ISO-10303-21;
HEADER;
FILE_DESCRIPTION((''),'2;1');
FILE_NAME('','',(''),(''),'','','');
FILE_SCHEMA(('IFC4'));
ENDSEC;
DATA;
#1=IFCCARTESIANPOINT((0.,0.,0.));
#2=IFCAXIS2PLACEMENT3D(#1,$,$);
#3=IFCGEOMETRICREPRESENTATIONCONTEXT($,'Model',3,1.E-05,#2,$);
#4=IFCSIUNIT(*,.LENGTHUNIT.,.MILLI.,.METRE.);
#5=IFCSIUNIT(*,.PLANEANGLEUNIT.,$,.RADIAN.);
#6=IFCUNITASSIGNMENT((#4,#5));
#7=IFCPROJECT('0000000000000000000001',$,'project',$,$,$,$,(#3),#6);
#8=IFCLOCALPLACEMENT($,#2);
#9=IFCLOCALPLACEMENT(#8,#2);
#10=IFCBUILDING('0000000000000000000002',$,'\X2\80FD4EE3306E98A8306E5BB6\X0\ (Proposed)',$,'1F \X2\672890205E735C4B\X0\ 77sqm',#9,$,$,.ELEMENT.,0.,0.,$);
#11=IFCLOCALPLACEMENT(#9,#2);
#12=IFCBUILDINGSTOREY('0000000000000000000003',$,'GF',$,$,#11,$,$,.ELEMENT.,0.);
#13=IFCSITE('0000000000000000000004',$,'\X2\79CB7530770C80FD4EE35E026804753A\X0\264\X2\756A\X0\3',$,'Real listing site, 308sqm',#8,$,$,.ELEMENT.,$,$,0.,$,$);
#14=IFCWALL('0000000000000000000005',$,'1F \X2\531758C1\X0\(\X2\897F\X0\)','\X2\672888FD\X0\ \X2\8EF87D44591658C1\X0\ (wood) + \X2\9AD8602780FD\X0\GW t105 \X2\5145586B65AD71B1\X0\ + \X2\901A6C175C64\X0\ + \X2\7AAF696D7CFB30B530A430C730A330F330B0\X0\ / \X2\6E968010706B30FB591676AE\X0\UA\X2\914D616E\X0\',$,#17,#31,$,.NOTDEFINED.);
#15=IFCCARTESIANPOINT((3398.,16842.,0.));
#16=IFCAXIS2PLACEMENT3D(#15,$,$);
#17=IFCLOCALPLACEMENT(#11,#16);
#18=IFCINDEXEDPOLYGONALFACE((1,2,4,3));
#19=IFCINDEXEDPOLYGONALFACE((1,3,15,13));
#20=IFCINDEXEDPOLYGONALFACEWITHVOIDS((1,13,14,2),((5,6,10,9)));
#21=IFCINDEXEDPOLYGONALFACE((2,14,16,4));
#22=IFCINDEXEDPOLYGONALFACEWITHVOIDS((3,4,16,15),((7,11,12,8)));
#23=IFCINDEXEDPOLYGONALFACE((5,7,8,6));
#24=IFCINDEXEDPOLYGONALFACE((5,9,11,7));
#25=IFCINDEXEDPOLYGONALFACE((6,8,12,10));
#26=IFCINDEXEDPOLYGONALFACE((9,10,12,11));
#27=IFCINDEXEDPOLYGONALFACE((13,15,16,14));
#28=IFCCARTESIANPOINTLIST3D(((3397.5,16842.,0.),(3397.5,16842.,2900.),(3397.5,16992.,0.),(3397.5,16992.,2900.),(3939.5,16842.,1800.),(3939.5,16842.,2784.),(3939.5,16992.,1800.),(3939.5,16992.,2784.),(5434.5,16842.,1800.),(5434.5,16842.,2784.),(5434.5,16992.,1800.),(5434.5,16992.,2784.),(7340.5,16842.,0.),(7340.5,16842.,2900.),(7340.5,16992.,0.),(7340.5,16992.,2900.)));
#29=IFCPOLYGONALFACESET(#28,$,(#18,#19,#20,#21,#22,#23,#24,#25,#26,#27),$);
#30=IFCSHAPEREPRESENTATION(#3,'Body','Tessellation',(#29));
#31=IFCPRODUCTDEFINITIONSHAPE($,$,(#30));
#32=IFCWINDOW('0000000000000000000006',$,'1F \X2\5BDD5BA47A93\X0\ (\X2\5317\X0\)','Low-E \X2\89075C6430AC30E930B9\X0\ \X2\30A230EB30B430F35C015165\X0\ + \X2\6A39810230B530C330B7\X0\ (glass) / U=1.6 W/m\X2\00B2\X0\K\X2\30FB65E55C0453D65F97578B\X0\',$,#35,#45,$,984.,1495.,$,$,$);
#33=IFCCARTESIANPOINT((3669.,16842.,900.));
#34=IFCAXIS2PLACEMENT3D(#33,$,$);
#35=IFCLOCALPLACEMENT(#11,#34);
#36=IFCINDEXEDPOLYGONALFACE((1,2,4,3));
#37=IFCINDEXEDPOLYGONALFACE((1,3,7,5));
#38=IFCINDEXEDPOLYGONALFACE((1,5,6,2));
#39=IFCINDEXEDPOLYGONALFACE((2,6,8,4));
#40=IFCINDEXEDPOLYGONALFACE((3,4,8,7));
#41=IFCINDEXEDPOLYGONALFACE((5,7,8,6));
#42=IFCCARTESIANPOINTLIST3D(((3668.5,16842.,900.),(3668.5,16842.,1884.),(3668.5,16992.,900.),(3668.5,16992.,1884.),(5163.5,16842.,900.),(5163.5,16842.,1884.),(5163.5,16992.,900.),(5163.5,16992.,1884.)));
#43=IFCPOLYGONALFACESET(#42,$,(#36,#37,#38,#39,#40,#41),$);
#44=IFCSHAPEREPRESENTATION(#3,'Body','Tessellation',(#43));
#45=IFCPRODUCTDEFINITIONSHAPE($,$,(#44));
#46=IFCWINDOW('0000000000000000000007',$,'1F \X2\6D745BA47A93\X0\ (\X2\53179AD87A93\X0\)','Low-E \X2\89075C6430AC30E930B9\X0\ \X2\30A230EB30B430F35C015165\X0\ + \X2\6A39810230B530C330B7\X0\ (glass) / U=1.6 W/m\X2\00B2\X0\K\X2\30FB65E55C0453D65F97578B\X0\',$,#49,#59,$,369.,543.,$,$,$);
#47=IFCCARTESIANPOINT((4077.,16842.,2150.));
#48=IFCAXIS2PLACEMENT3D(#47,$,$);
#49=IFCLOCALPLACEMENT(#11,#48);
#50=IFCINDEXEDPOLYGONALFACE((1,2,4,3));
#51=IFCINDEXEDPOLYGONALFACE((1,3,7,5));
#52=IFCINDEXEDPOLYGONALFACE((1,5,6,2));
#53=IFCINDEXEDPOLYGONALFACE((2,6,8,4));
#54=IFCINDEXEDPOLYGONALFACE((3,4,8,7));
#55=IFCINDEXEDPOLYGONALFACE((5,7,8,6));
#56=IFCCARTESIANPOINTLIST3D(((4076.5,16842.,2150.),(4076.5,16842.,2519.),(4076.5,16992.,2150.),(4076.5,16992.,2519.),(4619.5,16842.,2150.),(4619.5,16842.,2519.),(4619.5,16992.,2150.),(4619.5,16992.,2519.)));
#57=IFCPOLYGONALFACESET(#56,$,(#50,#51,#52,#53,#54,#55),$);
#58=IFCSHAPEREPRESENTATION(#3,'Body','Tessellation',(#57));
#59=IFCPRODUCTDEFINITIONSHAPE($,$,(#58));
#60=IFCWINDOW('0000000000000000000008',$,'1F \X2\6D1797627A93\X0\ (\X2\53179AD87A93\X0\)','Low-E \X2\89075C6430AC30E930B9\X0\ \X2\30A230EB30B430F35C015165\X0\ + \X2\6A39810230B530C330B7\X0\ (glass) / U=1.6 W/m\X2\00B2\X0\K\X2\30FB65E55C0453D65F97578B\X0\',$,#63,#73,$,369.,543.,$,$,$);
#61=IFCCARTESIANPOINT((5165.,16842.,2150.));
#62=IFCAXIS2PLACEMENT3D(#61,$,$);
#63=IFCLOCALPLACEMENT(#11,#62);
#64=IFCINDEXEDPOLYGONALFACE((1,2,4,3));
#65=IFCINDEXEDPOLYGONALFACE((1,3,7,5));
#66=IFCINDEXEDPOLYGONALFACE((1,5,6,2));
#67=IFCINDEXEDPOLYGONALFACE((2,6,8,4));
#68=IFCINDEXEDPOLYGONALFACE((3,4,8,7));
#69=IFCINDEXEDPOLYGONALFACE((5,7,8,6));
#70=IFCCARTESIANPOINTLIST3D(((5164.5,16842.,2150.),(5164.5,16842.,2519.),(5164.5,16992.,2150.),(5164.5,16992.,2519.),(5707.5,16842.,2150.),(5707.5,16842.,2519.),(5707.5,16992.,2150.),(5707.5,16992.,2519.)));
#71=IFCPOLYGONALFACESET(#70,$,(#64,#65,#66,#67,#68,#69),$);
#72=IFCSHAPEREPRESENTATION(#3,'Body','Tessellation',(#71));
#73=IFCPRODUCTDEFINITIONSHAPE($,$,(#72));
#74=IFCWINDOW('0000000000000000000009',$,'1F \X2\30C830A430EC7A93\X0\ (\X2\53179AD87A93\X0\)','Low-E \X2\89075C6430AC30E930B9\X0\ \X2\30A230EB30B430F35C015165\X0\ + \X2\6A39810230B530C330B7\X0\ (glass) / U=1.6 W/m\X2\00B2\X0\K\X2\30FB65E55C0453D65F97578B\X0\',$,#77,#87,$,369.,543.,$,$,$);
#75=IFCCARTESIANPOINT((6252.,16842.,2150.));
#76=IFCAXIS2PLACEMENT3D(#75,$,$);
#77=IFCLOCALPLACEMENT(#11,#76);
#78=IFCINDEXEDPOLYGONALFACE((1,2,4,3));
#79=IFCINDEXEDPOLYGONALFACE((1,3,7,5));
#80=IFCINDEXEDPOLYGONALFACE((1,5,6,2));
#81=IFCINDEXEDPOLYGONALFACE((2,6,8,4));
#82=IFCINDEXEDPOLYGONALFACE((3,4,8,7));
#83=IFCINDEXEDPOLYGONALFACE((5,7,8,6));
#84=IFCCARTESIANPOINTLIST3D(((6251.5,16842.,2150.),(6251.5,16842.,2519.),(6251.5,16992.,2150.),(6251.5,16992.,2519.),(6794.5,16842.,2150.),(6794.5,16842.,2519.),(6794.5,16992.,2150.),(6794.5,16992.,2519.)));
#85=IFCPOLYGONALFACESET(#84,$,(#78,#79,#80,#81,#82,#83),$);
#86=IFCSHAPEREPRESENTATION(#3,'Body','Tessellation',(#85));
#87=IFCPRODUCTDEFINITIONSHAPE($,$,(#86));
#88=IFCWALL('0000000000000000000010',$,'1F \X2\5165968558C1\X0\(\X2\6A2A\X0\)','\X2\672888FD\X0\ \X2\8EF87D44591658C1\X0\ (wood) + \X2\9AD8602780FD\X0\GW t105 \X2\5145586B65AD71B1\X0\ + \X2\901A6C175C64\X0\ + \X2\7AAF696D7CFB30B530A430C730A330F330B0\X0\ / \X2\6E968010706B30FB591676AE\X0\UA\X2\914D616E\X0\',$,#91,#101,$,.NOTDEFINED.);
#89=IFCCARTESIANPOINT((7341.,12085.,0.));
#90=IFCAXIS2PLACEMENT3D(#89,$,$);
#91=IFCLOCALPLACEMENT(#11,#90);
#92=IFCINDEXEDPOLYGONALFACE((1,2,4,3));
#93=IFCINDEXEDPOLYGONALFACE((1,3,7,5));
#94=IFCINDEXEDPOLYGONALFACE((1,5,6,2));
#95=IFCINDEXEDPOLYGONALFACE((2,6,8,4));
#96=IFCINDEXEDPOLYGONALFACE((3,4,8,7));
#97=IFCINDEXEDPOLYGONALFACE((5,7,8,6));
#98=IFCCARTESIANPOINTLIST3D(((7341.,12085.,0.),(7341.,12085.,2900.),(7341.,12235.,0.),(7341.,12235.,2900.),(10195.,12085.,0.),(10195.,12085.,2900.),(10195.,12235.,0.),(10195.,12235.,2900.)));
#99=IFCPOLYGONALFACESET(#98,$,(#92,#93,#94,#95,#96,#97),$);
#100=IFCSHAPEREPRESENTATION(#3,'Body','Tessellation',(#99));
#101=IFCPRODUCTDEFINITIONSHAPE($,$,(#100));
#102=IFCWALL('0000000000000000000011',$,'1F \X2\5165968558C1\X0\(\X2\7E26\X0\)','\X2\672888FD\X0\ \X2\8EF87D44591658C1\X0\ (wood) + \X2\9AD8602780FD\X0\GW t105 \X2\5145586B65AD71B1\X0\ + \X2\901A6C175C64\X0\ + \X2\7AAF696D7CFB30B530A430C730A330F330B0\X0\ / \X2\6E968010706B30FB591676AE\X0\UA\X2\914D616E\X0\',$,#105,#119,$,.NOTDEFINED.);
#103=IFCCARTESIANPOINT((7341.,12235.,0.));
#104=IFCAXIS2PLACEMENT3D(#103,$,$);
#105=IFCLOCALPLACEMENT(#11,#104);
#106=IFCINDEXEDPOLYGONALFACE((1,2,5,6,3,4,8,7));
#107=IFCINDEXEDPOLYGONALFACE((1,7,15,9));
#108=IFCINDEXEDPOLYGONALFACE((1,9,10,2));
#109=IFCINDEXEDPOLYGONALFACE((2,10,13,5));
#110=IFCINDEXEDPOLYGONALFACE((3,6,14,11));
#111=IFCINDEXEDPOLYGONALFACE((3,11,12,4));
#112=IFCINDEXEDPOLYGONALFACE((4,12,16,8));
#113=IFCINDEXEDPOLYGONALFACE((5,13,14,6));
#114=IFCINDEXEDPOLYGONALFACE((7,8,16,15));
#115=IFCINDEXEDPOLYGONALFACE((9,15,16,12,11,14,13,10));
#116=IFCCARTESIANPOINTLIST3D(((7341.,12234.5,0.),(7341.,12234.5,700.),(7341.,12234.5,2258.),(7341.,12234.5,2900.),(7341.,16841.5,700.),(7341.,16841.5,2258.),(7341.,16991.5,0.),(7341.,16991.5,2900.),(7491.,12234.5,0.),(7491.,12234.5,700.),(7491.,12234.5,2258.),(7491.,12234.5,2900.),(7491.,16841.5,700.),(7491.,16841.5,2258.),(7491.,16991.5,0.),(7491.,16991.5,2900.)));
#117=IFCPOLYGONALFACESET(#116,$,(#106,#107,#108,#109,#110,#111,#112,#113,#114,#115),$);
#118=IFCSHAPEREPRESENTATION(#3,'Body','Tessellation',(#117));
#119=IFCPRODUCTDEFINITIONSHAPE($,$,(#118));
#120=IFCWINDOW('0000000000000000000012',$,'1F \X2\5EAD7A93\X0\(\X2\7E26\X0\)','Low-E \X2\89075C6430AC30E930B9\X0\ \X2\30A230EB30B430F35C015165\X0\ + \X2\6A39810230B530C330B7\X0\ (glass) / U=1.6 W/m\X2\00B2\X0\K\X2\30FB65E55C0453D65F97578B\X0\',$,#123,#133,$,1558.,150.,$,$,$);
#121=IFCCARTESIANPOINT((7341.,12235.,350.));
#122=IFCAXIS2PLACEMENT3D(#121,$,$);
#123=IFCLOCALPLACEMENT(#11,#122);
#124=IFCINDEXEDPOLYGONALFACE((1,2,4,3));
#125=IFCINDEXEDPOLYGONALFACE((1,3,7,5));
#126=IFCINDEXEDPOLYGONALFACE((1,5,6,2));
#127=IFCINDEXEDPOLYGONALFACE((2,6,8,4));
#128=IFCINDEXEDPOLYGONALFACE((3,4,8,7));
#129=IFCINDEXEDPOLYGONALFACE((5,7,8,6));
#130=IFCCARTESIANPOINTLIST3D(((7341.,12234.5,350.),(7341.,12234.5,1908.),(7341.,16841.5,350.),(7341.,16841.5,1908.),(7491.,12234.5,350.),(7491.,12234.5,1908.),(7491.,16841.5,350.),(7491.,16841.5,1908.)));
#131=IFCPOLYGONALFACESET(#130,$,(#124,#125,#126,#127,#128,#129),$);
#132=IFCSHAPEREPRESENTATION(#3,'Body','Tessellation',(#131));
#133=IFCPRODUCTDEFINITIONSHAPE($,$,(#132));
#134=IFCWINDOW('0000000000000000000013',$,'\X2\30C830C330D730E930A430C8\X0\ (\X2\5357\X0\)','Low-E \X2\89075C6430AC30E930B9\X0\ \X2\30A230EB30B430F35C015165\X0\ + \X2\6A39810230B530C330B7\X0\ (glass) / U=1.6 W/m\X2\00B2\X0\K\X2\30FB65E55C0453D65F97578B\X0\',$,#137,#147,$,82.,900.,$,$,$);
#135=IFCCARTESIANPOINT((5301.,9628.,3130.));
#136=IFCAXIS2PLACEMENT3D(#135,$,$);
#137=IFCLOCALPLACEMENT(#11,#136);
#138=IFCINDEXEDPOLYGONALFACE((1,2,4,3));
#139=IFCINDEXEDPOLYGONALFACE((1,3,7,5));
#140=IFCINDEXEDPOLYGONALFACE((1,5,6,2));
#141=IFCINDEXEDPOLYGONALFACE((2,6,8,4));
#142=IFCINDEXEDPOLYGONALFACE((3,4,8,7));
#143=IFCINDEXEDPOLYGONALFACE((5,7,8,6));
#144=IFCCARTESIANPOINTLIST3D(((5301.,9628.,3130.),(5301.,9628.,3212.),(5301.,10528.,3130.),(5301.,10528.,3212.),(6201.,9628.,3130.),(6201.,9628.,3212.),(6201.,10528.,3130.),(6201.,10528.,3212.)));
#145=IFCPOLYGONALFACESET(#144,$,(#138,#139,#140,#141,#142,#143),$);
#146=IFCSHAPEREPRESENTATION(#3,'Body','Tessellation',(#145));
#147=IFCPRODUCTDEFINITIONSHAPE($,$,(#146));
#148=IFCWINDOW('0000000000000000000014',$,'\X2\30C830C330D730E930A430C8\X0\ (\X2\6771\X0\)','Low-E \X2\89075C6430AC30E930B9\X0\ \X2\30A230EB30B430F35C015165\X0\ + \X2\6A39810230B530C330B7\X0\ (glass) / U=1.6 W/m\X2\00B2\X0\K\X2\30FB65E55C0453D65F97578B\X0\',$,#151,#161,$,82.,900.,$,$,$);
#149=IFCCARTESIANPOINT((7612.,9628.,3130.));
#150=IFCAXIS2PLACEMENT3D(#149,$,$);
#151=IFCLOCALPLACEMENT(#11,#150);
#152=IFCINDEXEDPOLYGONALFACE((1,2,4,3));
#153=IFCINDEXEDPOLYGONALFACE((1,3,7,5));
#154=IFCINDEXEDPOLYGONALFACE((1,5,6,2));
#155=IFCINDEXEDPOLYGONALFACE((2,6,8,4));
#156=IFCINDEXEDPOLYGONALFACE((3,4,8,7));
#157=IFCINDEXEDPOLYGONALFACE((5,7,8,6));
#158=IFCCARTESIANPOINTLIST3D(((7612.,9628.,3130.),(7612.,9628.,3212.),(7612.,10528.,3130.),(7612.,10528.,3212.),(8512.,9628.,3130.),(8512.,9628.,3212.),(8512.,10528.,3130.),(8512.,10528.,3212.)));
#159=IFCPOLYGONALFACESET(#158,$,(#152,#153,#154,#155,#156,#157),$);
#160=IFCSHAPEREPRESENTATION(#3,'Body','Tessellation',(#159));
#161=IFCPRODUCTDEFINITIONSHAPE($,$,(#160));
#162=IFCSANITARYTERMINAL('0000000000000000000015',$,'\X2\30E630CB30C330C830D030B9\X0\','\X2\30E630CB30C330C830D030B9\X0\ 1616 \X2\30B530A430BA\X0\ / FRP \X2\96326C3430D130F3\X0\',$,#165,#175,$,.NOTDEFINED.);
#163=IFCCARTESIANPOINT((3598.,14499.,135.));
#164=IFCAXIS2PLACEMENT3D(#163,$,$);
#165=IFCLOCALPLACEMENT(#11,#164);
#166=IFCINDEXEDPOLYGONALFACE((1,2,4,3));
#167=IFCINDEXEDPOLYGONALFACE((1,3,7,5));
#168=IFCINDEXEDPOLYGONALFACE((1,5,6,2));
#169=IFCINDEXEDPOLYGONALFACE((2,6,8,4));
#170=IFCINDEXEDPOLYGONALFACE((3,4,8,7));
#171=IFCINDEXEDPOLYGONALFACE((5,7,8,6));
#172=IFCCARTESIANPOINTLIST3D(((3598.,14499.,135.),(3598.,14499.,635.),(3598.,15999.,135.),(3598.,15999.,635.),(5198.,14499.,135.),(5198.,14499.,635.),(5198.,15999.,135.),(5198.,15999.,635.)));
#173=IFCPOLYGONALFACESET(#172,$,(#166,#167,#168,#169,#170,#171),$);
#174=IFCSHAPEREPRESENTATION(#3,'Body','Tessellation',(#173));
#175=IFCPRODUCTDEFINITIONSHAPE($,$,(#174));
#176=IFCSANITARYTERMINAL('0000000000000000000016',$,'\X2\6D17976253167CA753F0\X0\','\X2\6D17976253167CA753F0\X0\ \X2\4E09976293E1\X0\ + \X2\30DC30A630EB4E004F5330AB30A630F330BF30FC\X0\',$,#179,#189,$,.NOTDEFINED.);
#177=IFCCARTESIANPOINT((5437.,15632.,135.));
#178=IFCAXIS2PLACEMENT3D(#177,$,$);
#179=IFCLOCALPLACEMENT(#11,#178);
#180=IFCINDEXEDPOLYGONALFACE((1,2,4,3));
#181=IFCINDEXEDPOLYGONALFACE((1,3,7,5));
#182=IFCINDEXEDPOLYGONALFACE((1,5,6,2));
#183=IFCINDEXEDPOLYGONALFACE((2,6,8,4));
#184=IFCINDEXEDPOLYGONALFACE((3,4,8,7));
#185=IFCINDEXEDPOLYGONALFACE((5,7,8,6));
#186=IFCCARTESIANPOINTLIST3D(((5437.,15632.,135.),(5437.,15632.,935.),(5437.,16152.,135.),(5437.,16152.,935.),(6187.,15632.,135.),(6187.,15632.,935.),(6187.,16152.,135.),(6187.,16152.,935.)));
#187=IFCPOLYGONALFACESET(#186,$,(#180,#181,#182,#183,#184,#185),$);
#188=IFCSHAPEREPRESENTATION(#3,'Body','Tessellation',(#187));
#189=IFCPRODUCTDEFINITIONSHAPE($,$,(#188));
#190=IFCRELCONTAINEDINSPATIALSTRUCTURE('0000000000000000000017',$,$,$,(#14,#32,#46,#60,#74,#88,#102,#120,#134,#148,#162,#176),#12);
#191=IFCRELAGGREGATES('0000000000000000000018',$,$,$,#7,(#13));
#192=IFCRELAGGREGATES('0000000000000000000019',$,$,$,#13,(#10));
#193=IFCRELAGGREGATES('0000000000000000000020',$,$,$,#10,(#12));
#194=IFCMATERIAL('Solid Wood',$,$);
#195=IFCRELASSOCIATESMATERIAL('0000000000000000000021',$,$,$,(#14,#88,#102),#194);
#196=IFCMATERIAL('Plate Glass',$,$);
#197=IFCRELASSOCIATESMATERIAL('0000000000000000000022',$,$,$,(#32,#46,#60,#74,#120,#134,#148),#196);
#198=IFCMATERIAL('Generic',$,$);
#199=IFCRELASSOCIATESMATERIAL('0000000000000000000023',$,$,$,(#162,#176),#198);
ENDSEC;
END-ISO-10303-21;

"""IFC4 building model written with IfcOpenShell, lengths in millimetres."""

from ifc_helpers import new_model, si_unit, frame, frame_2d, origin, place, context, project, spatial, rectangle, extrude, material, element, fill, save


model = new_model("IFC4")

# Units and contexts
model_context = context("Model", 3, precision=1e-05, world=origin())
ifc_project = project(units=[si_unit("LENGTHUNIT", "METRE", prefix="MILLI"), si_unit("PLANEANGLEUNIT", "RADIAN")], contexts=[model_context])

# Site, building, storey
site_placement = place(None, origin())
site = spatial("IfcSite", under=ifc_project, at=site_placement, Name="秋田県能代市栄町264番3", ObjectType="Real listing site, 308sqm", CompositionType="ELEMENT", RefElevation=0.0)
building_placement = place(site_placement, origin())
building = spatial("IfcBuilding", under=site, at=building_placement, Name="能代の風の家 (Proposed)", ObjectType="1F 木造平屋 77sqm", CompositionType="ELEMENT", ElevationOfRefHeight=0.0, ElevationOfTerrain=0.0)
storey_placement = place(building_placement, origin())
storey = spatial("IfcBuildingStorey", under=building, at=storey_placement, Name="GF", CompositionType="ELEMENT", Elevation=0.0)

# Shared definitions
ifc_material_1 = material(Name="Solid Wood")

# Wall, openings, windows
wall_1_placement = place(storey_placement, frame((3398.0, 16842.0, 0.0)))
wall_1 = element("IfcWall", 1, at=wall_1_placement, inside=storey, material=ifc_material_1, Name="1F 北壁(西)", Description="木製 軸組外壁 (wood) + 高性能GW t105 充填断熱 + 通気層 + 窯業系サイディング / 準耐火・外皮UA配慮", PredefinedType="NOTDEFINED", context=model_context, shape_type="SweptSolid", body=[
    extrude(rectangle(XDim=3943.0, YDim=150.0, at=frame_2d((1971.0, 75.0))), frame((3398.0, 16842.0, 0.0)), (0.0, 0.0, 1.0), 2900.0),
])
opening_1_placement = place(storey_placement, frame((3669.0, 16842.0, 900.0)))
opening_1 = element("IfcOpeningElement", 2, at=opening_1_placement, cuts=wall_1, PredefinedType="NOTDEFINED", context=model_context, shape_type="SweptSolid", body=[
    extrude(rectangle(XDim=1495.0, YDim=150.0, at=frame_2d((747.0, 75.0))), frame((3669.0, 16842.0, 900.0)), (0.0, 0.0, 1.0), 984.0),
])
opening_2_placement = place(storey_placement, frame((4077.0, 16842.0, 2150.0)))
opening_2 = element("IfcOpeningElement", 3, at=opening_2_placement, cuts=wall_1, PredefinedType="NOTDEFINED", context=model_context, shape_type="SweptSolid", body=[
    extrude(rectangle(XDim=543.0, YDim=150.0, at=frame_2d((271.0, 75.0))), frame((4077.0, 16842.0, 2150.0)), (0.0, 0.0, 1.0), 369.0),
])
opening_3_placement = place(storey_placement, frame((5165.0, 16842.0, 2150.0)))
opening_3 = element("IfcOpeningElement", 4, at=opening_3_placement, cuts=wall_1, PredefinedType="NOTDEFINED", context=model_context, shape_type="SweptSolid", body=[
    extrude(rectangle(XDim=543.0, YDim=150.0, at=frame_2d((271.0, 75.0))), frame((5165.0, 16842.0, 2150.0)), (0.0, 0.0, 1.0), 369.0),
])
opening_4_placement = place(storey_placement, frame((6252.0, 16842.0, 2150.0)))
opening_4 = element("IfcOpeningElement", 5, at=opening_4_placement, cuts=wall_1, PredefinedType="NOTDEFINED", context=model_context, shape_type="SweptSolid", body=[
    extrude(rectangle(XDim=543.0, YDim=150.0, at=frame_2d((271.0, 75.0))), frame((6252.0, 16842.0, 2150.0)), (0.0, 0.0, 1.0), 369.0),
])
ifc_material_2 = material(Name="Plate Glass")
window_1_placement = place(storey_placement, frame((3669.0, 16842.0, 900.0)))
window_1 = element("IfcWindow", 6, at=window_1_placement, inside=storey, material=ifc_material_2, Name="1F 寝室窓 (北)", Description="Low-E 複層ガラス アルゴン封入 + 樹脂サッシ (glass) / U=1.6 W/m²K・日射取得型", OverallHeight=984.0, OverallWidth=1495.0, context=model_context, shape_type="SweptSolid", body=[
    extrude(rectangle(XDim=1495.0, YDim=150.0, at=frame_2d((747.0, 75.0))), frame((3669.0, 16842.0, 900.0)), (0.0, 0.0, 1.0), 984.0),
])
fill(opening_1, window_1)
window_2_placement = place(storey_placement, frame((4077.0, 16842.0, 2150.0)))
window_2 = element("IfcWindow", 7, at=window_2_placement, inside=storey, material=ifc_material_2, Name="1F 浴室窓 (北高窓)", Description="Low-E 複層ガラス アルゴン封入 + 樹脂サッシ (glass) / U=1.6 W/m²K・日射取得型", OverallHeight=369.0, OverallWidth=543.0, context=model_context, shape_type="SweptSolid", body=[
    extrude(rectangle(XDim=543.0, YDim=150.0, at=frame_2d((271.0, 75.0))), frame((4077.0, 16842.0, 2150.0)), (0.0, 0.0, 1.0), 369.0),
])
fill(opening_2, window_2)
window_3_placement = place(storey_placement, frame((5165.0, 16842.0, 2150.0)))
window_3 = element("IfcWindow", 8, at=window_3_placement, inside=storey, material=ifc_material_2, Name="1F 洗面窓 (北高窓)", Description="Low-E 複層ガラス アルゴン封入 + 樹脂サッシ (glass) / U=1.6 W/m²K・日射取得型", OverallHeight=369.0, OverallWidth=543.0, context=model_context, shape_type="SweptSolid", body=[
    extrude(rectangle(XDim=543.0, YDim=150.0, at=frame_2d((271.0, 75.0))), frame((5165.0, 16842.0, 2150.0)), (0.0, 0.0, 1.0), 369.0),
])
fill(opening_3, window_3)
window_4_placement = place(storey_placement, frame((6252.0, 16842.0, 2150.0)))
window_4 = element("IfcWindow", 9, at=window_4_placement, inside=storey, material=ifc_material_2, Name="1F トイレ窓 (北高窓)", Description="Low-E 複層ガラス アルゴン封入 + 樹脂サッシ (glass) / U=1.6 W/m²K・日射取得型", OverallHeight=369.0, OverallWidth=543.0, context=model_context, shape_type="SweptSolid", body=[
    extrude(rectangle(XDim=543.0, YDim=150.0, at=frame_2d((271.0, 75.0))), frame((6252.0, 16842.0, 2150.0)), (0.0, 0.0, 1.0), 369.0),
])
fill(opening_4, window_4)

# Wall
wall_2_placement = place(storey_placement, frame((7341.0, 12085.0, 0.0)))
element("IfcWall", 10, at=wall_2_placement, inside=storey, material=ifc_material_1, Name="1F 入隅壁(横)", Description="木製 軸組外壁 (wood) + 高性能GW t105 充填断熱 + 通気層 + 窯業系サイディング / 準耐火・外皮UA配慮", PredefinedType="NOTDEFINED", context=model_context, shape_type="SweptSolid", body=[
    extrude(rectangle(XDim=2854.0, YDim=150.0, at=frame_2d((1427.0, 75.0))), frame((7341.0, 12085.0, 0.0)), (0.0, 0.0, 1.0), 2900.0),
])

# Wall, opening, window
wall_3_placement = place(storey_placement, frame((7341.0, 12235.0, 0.0)))
wall_3 = element("IfcWall", 11, at=wall_3_placement, inside=storey, material=ifc_material_1, Name="1F 入隅壁(縦)", Description="木製 軸組外壁 (wood) + 高性能GW t105 充填断熱 + 通気層 + 窯業系サイディング / 準耐火・外皮UA配慮", PredefinedType="NOTDEFINED", context=model_context, shape_type="SweptSolid", body=[
    extrude(rectangle(XDim=150.0, YDim=4757.0, at=frame_2d((75.0, 2378.0))), frame((7341.0, 12235.0, 0.0)), (0.0, 0.0, 1.0), 2900.0),
])
opening_5_placement = place(storey_placement, frame((7341.0, 12235.0, 350.0)))
opening_5 = element("IfcOpeningElement", 12, at=opening_5_placement, cuts=wall_3, PredefinedType="NOTDEFINED", context=model_context, shape_type="SweptSolid", body=[
    extrude(rectangle(XDim=150.0, YDim=4607.0, at=frame_2d((75.0, 2303.0))), frame((7341.0, 12235.0, 350.0)), (0.0, 0.0, 1.0), 1558.0),
])
window_5_placement = place(storey_placement, frame((7341.0, 12235.0, 350.0)))
window_5 = element("IfcWindow", 13, at=window_5_placement, inside=storey, material=ifc_material_2, Name="1F 庭窓(縦)", Description="Low-E 複層ガラス アルゴン封入 + 樹脂サッシ (glass) / U=1.6 W/m²K・日射取得型", OverallHeight=1558.0, OverallWidth=150.0, context=model_context, shape_type="SweptSolid", body=[
    extrude(rectangle(XDim=150.0, YDim=4607.0, at=frame_2d((75.0, 2303.0))), frame((7341.0, 12235.0, 350.0)), (0.0, 0.0, 1.0), 1558.0),
])
fill(opening_5, window_5)

# Windows
window_6_placement = place(storey_placement, frame((5301.0, 9628.0, 3130.0)))
element("IfcWindow", 14, at=window_6_placement, inside=storey, material=ifc_material_2, Name="トップライト (南)", Description="Low-E 複層ガラス アルゴン封入 + 樹脂サッシ (glass) / U=1.6 W/m²K・日射取得型", OverallHeight=82.0, OverallWidth=900.0, context=model_context, shape_type="SweptSolid", body=[
    extrude(rectangle(XDim=900.0, YDim=900.0, at=frame_2d((450.0, 450.0))), frame((5301.0, 9628.0, 3130.0)), (0.0, 0.0, 1.0), 82.0),
])
window_7_placement = place(storey_placement, frame((7612.0, 9628.0, 3130.0)))
element("IfcWindow", 15, at=window_7_placement, inside=storey, material=ifc_material_2, Name="トップライト (東)", Description="Low-E 複層ガラス アルゴン封入 + 樹脂サッシ (glass) / U=1.6 W/m²K・日射取得型", OverallHeight=82.0, OverallWidth=900.0, context=model_context, shape_type="SweptSolid", body=[
    extrude(rectangle(XDim=900.0, YDim=900.0, at=frame_2d((450.0, 450.0))), frame((7612.0, 9628.0, 3130.0)), (0.0, 0.0, 1.0), 82.0),
])

# Shared definitions
ifc_material_3 = material(Name="Generic")

# Sanitary terminals
sanitary_terminal_1_placement = place(storey_placement, frame((3598.0, 14499.0, 135.0)))
element("IfcSanitaryTerminal", 16, at=sanitary_terminal_1_placement, inside=storey, material=ifc_material_3, Name="ユニットバス", Description="ユニットバス 1616 サイズ / FRP 防水パン", PredefinedType="NOTDEFINED", context=model_context, shape_type="SweptSolid", body=[
    extrude(rectangle(XDim=1600.0, YDim=1500.0, at=frame_2d((800.0, 750.0))), frame((3598.0, 14499.0, 135.0)), (0.0, 0.0, 1.0), 500.0),
])
sanitary_terminal_2_placement = place(storey_placement, frame((5437.0, 15632.0, 135.0)))
element("IfcSanitaryTerminal", 17, at=sanitary_terminal_2_placement, inside=storey, material=ifc_material_3, Name="洗面化粧台", Description="洗面化粧台 三面鏡 + ボウル一体カウンター", PredefinedType="NOTDEFINED", context=model_context, shape_type="SweptSolid", body=[
    extrude(rectangle(XDim=750.0, YDim=520.0, at=frame_2d((375.0, 260.0))), frame((5437.0, 15632.0, 135.0)), (0.0, 0.0, 1.0), 800.0),
])

save(model, "model.ifc")
